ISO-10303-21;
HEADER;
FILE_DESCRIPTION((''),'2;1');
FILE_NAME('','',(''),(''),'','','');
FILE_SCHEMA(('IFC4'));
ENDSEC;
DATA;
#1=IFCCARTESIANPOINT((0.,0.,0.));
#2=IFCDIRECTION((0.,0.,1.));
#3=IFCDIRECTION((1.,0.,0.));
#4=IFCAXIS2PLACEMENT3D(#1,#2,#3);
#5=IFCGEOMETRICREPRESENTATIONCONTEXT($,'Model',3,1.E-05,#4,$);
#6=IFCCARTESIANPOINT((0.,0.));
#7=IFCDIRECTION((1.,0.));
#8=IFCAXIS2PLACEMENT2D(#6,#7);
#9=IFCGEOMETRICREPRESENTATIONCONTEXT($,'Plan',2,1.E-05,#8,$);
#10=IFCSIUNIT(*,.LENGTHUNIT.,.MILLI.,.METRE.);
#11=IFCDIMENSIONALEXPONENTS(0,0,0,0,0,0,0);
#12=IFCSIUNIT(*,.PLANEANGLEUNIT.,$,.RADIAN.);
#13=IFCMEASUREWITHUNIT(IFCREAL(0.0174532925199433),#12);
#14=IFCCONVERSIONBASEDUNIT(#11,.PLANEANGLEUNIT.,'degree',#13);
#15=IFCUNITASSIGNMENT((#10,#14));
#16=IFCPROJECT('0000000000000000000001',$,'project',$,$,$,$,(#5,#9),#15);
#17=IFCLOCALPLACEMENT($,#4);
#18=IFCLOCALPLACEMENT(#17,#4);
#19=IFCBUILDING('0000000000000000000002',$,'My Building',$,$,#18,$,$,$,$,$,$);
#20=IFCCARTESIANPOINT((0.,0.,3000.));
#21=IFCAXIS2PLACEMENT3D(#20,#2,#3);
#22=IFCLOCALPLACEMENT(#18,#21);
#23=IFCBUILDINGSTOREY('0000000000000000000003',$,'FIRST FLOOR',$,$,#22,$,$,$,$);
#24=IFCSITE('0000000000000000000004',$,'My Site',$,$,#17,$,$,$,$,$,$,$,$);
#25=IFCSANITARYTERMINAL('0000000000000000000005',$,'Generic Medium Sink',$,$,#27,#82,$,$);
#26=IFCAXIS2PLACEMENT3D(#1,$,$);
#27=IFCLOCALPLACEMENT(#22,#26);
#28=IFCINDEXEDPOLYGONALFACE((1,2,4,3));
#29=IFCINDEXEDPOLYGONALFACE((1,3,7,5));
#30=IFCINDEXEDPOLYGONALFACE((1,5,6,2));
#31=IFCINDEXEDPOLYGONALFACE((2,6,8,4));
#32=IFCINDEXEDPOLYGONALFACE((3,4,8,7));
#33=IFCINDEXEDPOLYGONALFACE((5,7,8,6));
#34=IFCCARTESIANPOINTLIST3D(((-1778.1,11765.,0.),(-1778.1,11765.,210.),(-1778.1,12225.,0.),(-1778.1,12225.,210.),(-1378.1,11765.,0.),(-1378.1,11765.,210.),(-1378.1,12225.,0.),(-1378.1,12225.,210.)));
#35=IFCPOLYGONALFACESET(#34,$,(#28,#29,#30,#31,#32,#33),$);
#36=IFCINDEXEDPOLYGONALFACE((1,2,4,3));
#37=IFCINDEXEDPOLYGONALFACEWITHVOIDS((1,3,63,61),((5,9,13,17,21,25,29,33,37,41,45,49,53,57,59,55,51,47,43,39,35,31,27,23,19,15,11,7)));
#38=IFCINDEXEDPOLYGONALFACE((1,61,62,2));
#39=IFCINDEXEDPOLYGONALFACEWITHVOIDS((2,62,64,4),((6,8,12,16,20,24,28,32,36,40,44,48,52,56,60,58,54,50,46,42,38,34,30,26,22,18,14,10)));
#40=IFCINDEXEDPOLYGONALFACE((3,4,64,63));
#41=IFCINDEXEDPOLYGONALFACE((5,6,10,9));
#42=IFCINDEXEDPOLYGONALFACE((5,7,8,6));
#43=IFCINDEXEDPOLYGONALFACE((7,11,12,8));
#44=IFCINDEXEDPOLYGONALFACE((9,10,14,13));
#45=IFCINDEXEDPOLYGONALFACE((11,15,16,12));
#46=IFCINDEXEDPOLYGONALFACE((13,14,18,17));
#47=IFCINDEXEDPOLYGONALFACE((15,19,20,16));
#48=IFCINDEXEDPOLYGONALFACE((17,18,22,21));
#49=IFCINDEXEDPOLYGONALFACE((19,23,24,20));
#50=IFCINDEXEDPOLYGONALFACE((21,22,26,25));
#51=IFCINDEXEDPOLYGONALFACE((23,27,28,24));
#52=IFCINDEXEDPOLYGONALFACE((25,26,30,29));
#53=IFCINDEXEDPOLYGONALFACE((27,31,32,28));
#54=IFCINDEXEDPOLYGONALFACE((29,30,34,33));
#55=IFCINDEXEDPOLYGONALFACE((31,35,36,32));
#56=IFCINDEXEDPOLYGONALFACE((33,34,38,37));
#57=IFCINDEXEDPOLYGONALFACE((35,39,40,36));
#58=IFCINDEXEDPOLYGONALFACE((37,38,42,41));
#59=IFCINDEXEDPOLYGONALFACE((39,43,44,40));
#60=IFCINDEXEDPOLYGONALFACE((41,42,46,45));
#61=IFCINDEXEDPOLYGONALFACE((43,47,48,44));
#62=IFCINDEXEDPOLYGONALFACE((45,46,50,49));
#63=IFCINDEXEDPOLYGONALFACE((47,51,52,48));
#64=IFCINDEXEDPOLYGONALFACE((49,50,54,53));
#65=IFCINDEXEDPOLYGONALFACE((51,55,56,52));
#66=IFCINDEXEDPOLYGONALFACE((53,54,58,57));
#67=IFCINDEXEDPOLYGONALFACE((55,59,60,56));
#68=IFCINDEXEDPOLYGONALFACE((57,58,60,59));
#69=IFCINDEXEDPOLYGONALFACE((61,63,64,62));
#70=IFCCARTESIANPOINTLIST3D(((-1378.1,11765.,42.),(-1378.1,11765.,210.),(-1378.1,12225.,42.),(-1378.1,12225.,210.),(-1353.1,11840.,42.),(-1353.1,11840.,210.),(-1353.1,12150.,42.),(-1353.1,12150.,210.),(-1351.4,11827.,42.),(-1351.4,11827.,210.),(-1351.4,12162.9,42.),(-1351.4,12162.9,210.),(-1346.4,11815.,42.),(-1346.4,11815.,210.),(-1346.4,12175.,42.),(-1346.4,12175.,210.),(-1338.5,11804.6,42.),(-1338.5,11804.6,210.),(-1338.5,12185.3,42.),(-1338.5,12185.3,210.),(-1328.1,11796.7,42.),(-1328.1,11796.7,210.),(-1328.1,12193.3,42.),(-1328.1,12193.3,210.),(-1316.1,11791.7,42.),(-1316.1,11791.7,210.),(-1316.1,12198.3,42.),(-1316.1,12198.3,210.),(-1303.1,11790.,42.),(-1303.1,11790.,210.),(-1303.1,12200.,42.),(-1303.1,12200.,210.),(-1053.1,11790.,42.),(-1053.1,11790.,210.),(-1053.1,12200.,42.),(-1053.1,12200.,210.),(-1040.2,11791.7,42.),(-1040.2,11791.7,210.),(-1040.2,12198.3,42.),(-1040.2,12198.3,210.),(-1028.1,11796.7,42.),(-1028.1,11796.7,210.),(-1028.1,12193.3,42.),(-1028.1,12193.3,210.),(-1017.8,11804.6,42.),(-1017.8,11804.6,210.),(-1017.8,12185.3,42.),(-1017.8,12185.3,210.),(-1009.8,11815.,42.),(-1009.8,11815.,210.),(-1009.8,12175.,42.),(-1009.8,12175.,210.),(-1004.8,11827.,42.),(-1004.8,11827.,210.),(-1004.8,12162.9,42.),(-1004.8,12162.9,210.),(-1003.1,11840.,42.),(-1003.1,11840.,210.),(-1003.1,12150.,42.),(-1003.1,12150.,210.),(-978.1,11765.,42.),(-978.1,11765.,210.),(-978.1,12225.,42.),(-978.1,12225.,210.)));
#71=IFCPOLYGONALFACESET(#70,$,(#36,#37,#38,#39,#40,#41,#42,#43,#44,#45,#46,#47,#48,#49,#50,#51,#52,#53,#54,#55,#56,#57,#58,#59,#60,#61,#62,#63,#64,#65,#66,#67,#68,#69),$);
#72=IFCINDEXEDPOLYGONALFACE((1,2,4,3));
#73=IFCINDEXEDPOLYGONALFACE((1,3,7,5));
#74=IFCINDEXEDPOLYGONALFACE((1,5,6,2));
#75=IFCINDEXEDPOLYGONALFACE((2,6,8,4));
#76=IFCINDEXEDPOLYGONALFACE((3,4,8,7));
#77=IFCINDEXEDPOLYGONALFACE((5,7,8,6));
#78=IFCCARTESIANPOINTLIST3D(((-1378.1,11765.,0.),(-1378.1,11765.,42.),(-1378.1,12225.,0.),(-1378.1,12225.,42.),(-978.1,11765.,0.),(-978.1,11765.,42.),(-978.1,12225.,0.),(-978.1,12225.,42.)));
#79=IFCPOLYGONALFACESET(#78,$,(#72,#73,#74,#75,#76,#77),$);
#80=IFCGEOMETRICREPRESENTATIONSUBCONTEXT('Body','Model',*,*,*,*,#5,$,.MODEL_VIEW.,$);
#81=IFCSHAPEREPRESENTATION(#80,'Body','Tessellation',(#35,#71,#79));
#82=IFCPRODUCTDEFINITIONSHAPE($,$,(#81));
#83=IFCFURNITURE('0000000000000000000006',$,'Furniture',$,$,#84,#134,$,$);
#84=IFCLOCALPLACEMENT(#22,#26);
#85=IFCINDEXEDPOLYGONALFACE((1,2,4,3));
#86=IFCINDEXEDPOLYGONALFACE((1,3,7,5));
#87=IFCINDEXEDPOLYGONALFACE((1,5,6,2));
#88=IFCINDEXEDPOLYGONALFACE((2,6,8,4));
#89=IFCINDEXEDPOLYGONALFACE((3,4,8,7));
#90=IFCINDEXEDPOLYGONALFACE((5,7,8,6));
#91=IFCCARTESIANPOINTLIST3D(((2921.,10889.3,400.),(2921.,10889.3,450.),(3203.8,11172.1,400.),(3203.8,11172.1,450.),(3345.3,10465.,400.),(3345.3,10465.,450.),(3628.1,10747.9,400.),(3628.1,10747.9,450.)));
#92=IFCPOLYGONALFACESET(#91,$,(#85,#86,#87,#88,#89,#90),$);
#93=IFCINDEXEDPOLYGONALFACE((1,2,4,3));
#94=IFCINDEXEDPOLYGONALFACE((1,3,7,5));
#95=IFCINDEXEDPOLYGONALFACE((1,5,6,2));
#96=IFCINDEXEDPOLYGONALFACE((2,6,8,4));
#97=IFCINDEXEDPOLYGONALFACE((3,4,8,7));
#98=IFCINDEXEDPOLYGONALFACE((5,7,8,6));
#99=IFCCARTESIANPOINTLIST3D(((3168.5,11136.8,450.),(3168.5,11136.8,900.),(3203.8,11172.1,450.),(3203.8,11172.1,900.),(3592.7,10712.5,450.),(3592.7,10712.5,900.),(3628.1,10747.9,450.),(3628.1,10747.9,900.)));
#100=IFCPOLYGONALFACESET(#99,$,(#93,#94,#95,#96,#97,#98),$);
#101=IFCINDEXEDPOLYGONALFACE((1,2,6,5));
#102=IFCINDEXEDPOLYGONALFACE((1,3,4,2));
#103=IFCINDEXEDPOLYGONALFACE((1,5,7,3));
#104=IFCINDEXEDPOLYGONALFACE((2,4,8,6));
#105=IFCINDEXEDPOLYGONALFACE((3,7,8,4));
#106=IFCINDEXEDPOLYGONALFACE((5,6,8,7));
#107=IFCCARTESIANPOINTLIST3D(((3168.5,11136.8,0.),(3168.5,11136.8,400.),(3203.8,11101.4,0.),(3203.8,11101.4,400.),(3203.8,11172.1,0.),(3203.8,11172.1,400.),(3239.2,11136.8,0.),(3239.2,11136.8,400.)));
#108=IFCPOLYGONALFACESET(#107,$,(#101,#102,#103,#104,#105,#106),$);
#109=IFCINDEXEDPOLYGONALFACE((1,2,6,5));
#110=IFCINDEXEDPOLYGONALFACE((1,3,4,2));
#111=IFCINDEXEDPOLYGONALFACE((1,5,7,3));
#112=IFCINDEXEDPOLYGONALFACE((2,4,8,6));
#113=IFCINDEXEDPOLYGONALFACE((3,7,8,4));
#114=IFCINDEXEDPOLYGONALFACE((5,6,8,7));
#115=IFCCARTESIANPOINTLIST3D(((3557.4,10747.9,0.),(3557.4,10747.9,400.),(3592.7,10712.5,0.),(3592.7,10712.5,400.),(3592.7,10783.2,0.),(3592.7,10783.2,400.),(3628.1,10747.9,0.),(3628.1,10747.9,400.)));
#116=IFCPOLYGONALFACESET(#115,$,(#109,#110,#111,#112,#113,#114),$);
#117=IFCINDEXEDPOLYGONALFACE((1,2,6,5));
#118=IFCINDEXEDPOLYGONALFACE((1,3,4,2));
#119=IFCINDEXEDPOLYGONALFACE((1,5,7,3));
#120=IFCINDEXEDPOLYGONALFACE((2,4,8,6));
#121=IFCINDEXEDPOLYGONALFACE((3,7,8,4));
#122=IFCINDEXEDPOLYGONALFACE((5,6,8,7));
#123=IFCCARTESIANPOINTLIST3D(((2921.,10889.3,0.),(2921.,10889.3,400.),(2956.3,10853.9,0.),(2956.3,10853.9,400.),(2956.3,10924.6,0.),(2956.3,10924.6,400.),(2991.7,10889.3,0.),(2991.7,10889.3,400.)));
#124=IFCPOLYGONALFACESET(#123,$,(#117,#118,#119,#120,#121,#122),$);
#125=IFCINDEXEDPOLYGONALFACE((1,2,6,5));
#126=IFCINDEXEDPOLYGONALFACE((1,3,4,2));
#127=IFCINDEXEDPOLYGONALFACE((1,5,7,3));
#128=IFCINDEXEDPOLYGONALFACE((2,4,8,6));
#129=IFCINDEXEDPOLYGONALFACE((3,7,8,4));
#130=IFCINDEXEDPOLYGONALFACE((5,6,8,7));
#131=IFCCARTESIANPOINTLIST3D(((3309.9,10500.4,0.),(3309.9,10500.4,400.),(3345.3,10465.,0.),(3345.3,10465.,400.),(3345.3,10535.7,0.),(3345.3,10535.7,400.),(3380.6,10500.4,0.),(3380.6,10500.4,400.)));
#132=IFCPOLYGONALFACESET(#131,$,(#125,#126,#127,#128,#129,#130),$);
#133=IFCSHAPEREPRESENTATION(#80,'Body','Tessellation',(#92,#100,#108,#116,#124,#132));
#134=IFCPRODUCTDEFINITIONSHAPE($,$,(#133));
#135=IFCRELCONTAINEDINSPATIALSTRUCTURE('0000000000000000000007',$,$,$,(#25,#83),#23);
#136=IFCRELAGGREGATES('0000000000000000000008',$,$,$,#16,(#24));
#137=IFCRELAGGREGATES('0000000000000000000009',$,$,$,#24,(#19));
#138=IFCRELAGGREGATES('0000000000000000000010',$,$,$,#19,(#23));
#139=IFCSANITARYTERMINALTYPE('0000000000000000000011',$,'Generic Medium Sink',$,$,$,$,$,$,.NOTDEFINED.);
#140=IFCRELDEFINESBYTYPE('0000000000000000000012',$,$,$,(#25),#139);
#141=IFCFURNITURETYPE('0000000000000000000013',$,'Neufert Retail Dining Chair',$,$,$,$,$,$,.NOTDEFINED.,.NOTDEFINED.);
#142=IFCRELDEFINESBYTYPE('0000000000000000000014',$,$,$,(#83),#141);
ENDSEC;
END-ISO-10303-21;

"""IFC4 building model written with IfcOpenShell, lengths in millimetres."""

from ifc_helpers import new_model, entity, si_unit, converted_unit, frame, origin_with_axes, origin_2d_with_axis, place, context, subcontext, project, spatial, line, indexed_curve, outline, extrude, shape, source, transform, mapped, type_object, type_shapes, element, save


model = new_model("IFC4")

# Units and contexts
model_context = context("Model", 3, precision=1e-05, world=origin_with_axes())
plan_context = context("Plan", 2, precision=1e-05, world=origin_2d_with_axis())
body_context_1 = subcontext(model_context, "Body", "Model", "MODEL_VIEW")
body_context_2 = subcontext(plan_context, "Body", "Plan", "PLAN_VIEW")
ifc_project = project(units=[si_unit("LENGTHUNIT", "METRE", prefix="MILLI"), converted_unit("PLANEANGLEUNIT", "degree", entity("IfcReal", 0.0174532925199433), si_unit("PLANEANGLEUNIT", "RADIAN"), dimensions=[0, 0, 0, 0, 0, 0, 0])], contexts=[model_context, plan_context])

# Site, building, storey
site_placement = place(None, origin_with_axes())
site = spatial("IfcSite", under=ifc_project, at=site_placement, Name="My Site")
building_placement = place(site_placement, origin_with_axes())
building = spatial("IfcBuilding", under=site, at=building_placement, Name="My Building")
storey_placement = place(building_placement, frame((0.0, 0.0, 3000.0), z_axis=(0.0, 0.0, 1.0), x_axis=(1.0, 0.0, 0.0)))
storey = spatial("IfcBuildingStorey", under=building, at=storey_placement, Name="FIRST FLOOR")

# Sanitary terminal
sanitary_terminal_type_1 = type_object("IfcSanitaryTerminalType", Name="Generic Medium Sink", PredefinedType="NOTDEFINED")
shared_indexed_poly_curve = entity("IfcIndexedPolyCurve", entity("IfcCartesianPointList2D", [[400.0, 0.0], [800.0, 0.0], [800.0, 460.0], [400.0, 460.0]]), [entity("IfcLineIndex", [1, 2]), entity("IfcLineIndex", [2, 3]), entity("IfcLineIndex", [3, 4]), entity("IfcLineIndex", [4, 1])])
shared_shape_1 = source(origin_with_axes(), body_context_1, "Body", "SweptSolid", [
    extrude(outline(indexed_curve([(0.0, 0.0), (400.0, 0.0), (400.0, 460.0), (0.0, 460.0)], segments=[line(1, 2), line(2, 3), line(3, 4), line(4, 1)])), frame((-400.0, -460.0, 0.0), z_axis=(0.0, 0.0, 1.0), x_axis=(1.0, 0.0, 0.0)), (0.0, 0.0, 1.0), 210.0),
    entity("IfcExtrudedAreaSolid", entity("IfcArbitraryProfileDefWithVoids", "AREA", None, shared_indexed_poly_curve, [entity("IfcIndexedPolyCurve", entity("IfcCartesianPointList2D", [[425.0, 75.0], [439.6, 39.6], [475.0, 25.0], [725.0, 25.0], [760.4, 39.6], [775.0, 75.0], [775.0, 385.0], [760.4, 420.4], [725.0, 435.0], [475.0, 435.0], [439.6, 420.4], [425.0, 385.0]]), [entity("IfcLineIndex", [12, 1]), entity("IfcArcIndex", [1, 2, 3]), entity("IfcLineIndex", [3, 4]), entity("IfcArcIndex", [4, 5, 6]), entity("IfcLineIndex", [6, 7]), entity("IfcArcIndex", [7, 8, 9]), entity("IfcLineIndex", [9, 10]), entity("IfcArcIndex", [10, 11, 12]), entity("IfcLineIndex", [12, 1])])]), entity("IfcAxis2Placement3D", entity("IfcCartesianPoint", [-400.0, -460.0, 42.0]), entity("IfcDirection", [0.0, 0.0, 1.0]), entity("IfcDirection", [1.0, 0.0, 0.0])), entity("IfcDirection", [0.0, 0.0, 1.0]), 168.0),
    entity("IfcExtrudedAreaSolid", entity("IfcArbitraryClosedProfileDef", "AREA", None, shared_indexed_poly_curve), entity("IfcAxis2Placement3D", entity("IfcCartesianPoint", [-400.0, -460.0, 0.0]), entity("IfcDirection", [0.0, 0.0, 1.0]), entity("IfcDirection", [1.0, 0.0, 0.0])), entity("IfcDirection", [0.0, 0.0, 1.0]), 42.0),
])
shared_shape_2 = source(origin_with_axes(), body_context_2, "Body", "Curve2D", [
    entity("IfcIndexedPolyCurve", entity("IfcCartesianPointList2D", [[-400.0, -460.0], [400.0, -460.0], [400.0, 0.0], [-400.0, 0.0]]), [entity("IfcLineIndex", [1, 2]), entity("IfcLineIndex", [2, 3]), entity("IfcLineIndex", [3, 4]), entity("IfcLineIndex", [4, 1])]),
    entity("IfcIndexedPolyCurve", entity("IfcCartesianPointList2D", [[25.0, -385.0], [39.6, -420.4], [75.0, -435.0], [325.0, -435.0], [360.4, -420.4], [375.0, -385.0], [375.0, -75.0], [360.4, -39.6], [325.0, -25.0], [75.0, -25.0], [39.6, -39.6], [25.0, -75.0]]), [entity("IfcLineIndex", [12, 1]), entity("IfcArcIndex", [1, 2, 3]), entity("IfcLineIndex", [3, 4]), entity("IfcArcIndex", [4, 5, 6]), entity("IfcLineIndex", [6, 7]), entity("IfcArcIndex", [7, 8, 9]), entity("IfcLineIndex", [9, 10]), entity("IfcArcIndex", [10, 11, 12]), entity("IfcLineIndex", [12, 1])]),
    entity("IfcCircle", entity("IfcAxis2Placement2D", entity("IfcCartesianPoint", [200.0, -125.0])), 25.0),
    entity("IfcIndexedPolyCurve", entity("IfcCartesianPointList2D", [[200.0, -12.5], [200.0, -132.5]]), [entity("IfcLineIndex", [1, 2])]),
])
type_shapes(sanitary_terminal_type_1, [shared_shape_1, shared_shape_2])
sanitary_terminal_1_placement = place(storey_placement, frame((-1378.1, 12225.0, 0.0), z_axis=(0.0, 0.0, 1.0), x_axis=(1.0, 0.0, 0.0)))
element("IfcSanitaryTerminal", 1, at=sanitary_terminal_1_placement, inside=storey, type_object=sanitary_terminal_type_1, Name="Generic Medium Sink", shapes=[
    shape(body_context_1, "Body", "MappedRepresentation", [mapped(shared_shape_1, transform((0.0, 0.0, 0.0), x_axis=(1.0, 0.0, 0.0), y_axis=(0.0, 1.0, 0.0), z_axis=(0.0, 0.0, 1.0), scale=1.0))]),
    shape(body_context_2, "Body", "MappedRepresentation", [mapped(shared_shape_2, transform((0.0, 0.0, 0.0), x_axis=(1.0, 0.0, 0.0), y_axis=(0.0, 1.0, 0.0), z_axis=(0.0, 0.0, 1.0), scale=1.0))]),
])

# Furniture
furniture_type = type_object("IfcFurnitureType", Name="Neufert Retail Dining Chair", AssemblyPlace="NOTDEFINED", PredefinedType="NOTDEFINED")
shared_shape_3 = source(origin_with_axes(), body_context_1, "Body", "SweptSolid", [
    extrude(outline(indexed_curve([(-300.0, 0.0), (300.0, 0.0), (300.0, -400.0), (-300.0, -400.0)], segments=[line(1, 2), line(2, 3), line(3, 4), line(4, 1)])), frame((0.0, 0.0, 450.0), z_axis=(0.0, 0.0, 1.0), x_axis=(1.0, 0.0, 0.0)), (0.0, 0.0, -1.0), 50.0),
    extrude(outline(indexed_curve([(-300.0, 0.0), (300.0, 0.0), (300.0, -50.0), (-300.0, -50.0)], segments=[line(1, 2), line(2, 3), line(3, 4), line(4, 1)])), frame((0.0, 0.0, 900.0), z_axis=(0.0, 0.0, 1.0), x_axis=(1.0, 0.0, 0.0)), (0.0, 0.0, -1.0), 450.0),
    extrude(outline(indexed_curve([(-300.0, 0.0), (-250.0, 0.0), (-250.0, -50.0), (-300.0, -50.0)], segments=[line(1, 2), line(2, 3), line(3, 4), line(4, 1)])), origin_with_axes(), (0.0, 0.0, 1.0), 400.0),
    extrude(outline(indexed_curve([(300.0, 0.0), (250.0, 0.0), (250.0, -50.0), (300.0, -50.0)], segments=[line(1, 2), line(2, 3), line(3, 4), line(4, 1)])), origin_with_axes(), (0.0, 0.0, 1.0), 400.0),
    extrude(outline(indexed_curve([(-300.0, -400.0), (-250.0, -400.0), (-250.0, -350.0), (-300.0, -350.0)], segments=[line(1, 2), line(2, 3), line(3, 4), line(4, 1)])), origin_with_axes(), (0.0, 0.0, 1.0), 400.0),
    extrude(outline(indexed_curve([(300.0, -400.0), (250.0, -400.0), (250.0, -350.0), (300.0, -350.0)], segments=[line(1, 2), line(2, 3), line(3, 4), line(4, 1)])), origin_with_axes(), (0.0, 0.0, 1.0), 400.0),
])
shared_shape_4 = source(origin_with_axes(), body_context_2, "Body", "Curve2D", [
    entity("IfcIndexedPolyCurve", entity("IfcCartesianPointList2D", [[-300.0, -400.0], [300.0, -400.0]]), [entity("IfcLineIndex", [1, 2])]),
    entity("IfcIndexedPolyCurve", entity("IfcCartesianPointList2D", [[-300.0, -400.0], [-300.0, -300.0], [-212.1, -87.9], [0.0, 0.0], [212.1, -87.9], [300.0, -300.0], [300.0, -400.0]]), [entity("IfcLineIndex", [1, 2]), entity("IfcArcIndex", [2, 3, 4]), entity("IfcArcIndex", [4, 5, 6]), entity("IfcLineIndex", [6, 7])]),
    entity("IfcIndexedPolyCurve", entity("IfcCartesianPointList2D", [[-260.0, -400.0], [-260.0, -300.0], [-183.8, -116.2], [0.0, -40.0], [183.8, -116.2], [260.0, -300.0], [260.0, -400.0]]), [entity("IfcLineIndex", [1, 2]), entity("IfcArcIndex", [2, 3, 4]), entity("IfcArcIndex", [4, 5, 6]), entity("IfcLineIndex", [6, 7])]),
])
type_shapes(furniture_type, [shared_shape_3, shared_shape_4])
furniture_placement = place(storey_placement, frame((3416.0, 10960.0, 0.0), z_axis=(0.0, 0.0, 1.0), x_axis=(0.707107, -0.707107, 0.0)))
element("IfcFurniture", 2, at=furniture_placement, inside=storey, type_object=furniture_type, Name="Furniture", shapes=[
    shape(body_context_1, "Body", "MappedRepresentation", [mapped(shared_shape_3, transform((0.0, 0.0, 0.0), x_axis=(1.0, 0.0, 0.0), y_axis=(0.0, 1.0, 0.0), z_axis=(0.0, 0.0, 1.0), scale=1.0))]),
    shape(body_context_2, "Body", "MappedRepresentation", [mapped(shared_shape_4, transform((0.0, 0.0, 0.0), x_axis=(1.0, 0.0, 0.0), y_axis=(0.0, 1.0, 0.0), z_axis=(0.0, 0.0, 1.0), scale=1.0))]),
])

save(model, "model.ifc")
